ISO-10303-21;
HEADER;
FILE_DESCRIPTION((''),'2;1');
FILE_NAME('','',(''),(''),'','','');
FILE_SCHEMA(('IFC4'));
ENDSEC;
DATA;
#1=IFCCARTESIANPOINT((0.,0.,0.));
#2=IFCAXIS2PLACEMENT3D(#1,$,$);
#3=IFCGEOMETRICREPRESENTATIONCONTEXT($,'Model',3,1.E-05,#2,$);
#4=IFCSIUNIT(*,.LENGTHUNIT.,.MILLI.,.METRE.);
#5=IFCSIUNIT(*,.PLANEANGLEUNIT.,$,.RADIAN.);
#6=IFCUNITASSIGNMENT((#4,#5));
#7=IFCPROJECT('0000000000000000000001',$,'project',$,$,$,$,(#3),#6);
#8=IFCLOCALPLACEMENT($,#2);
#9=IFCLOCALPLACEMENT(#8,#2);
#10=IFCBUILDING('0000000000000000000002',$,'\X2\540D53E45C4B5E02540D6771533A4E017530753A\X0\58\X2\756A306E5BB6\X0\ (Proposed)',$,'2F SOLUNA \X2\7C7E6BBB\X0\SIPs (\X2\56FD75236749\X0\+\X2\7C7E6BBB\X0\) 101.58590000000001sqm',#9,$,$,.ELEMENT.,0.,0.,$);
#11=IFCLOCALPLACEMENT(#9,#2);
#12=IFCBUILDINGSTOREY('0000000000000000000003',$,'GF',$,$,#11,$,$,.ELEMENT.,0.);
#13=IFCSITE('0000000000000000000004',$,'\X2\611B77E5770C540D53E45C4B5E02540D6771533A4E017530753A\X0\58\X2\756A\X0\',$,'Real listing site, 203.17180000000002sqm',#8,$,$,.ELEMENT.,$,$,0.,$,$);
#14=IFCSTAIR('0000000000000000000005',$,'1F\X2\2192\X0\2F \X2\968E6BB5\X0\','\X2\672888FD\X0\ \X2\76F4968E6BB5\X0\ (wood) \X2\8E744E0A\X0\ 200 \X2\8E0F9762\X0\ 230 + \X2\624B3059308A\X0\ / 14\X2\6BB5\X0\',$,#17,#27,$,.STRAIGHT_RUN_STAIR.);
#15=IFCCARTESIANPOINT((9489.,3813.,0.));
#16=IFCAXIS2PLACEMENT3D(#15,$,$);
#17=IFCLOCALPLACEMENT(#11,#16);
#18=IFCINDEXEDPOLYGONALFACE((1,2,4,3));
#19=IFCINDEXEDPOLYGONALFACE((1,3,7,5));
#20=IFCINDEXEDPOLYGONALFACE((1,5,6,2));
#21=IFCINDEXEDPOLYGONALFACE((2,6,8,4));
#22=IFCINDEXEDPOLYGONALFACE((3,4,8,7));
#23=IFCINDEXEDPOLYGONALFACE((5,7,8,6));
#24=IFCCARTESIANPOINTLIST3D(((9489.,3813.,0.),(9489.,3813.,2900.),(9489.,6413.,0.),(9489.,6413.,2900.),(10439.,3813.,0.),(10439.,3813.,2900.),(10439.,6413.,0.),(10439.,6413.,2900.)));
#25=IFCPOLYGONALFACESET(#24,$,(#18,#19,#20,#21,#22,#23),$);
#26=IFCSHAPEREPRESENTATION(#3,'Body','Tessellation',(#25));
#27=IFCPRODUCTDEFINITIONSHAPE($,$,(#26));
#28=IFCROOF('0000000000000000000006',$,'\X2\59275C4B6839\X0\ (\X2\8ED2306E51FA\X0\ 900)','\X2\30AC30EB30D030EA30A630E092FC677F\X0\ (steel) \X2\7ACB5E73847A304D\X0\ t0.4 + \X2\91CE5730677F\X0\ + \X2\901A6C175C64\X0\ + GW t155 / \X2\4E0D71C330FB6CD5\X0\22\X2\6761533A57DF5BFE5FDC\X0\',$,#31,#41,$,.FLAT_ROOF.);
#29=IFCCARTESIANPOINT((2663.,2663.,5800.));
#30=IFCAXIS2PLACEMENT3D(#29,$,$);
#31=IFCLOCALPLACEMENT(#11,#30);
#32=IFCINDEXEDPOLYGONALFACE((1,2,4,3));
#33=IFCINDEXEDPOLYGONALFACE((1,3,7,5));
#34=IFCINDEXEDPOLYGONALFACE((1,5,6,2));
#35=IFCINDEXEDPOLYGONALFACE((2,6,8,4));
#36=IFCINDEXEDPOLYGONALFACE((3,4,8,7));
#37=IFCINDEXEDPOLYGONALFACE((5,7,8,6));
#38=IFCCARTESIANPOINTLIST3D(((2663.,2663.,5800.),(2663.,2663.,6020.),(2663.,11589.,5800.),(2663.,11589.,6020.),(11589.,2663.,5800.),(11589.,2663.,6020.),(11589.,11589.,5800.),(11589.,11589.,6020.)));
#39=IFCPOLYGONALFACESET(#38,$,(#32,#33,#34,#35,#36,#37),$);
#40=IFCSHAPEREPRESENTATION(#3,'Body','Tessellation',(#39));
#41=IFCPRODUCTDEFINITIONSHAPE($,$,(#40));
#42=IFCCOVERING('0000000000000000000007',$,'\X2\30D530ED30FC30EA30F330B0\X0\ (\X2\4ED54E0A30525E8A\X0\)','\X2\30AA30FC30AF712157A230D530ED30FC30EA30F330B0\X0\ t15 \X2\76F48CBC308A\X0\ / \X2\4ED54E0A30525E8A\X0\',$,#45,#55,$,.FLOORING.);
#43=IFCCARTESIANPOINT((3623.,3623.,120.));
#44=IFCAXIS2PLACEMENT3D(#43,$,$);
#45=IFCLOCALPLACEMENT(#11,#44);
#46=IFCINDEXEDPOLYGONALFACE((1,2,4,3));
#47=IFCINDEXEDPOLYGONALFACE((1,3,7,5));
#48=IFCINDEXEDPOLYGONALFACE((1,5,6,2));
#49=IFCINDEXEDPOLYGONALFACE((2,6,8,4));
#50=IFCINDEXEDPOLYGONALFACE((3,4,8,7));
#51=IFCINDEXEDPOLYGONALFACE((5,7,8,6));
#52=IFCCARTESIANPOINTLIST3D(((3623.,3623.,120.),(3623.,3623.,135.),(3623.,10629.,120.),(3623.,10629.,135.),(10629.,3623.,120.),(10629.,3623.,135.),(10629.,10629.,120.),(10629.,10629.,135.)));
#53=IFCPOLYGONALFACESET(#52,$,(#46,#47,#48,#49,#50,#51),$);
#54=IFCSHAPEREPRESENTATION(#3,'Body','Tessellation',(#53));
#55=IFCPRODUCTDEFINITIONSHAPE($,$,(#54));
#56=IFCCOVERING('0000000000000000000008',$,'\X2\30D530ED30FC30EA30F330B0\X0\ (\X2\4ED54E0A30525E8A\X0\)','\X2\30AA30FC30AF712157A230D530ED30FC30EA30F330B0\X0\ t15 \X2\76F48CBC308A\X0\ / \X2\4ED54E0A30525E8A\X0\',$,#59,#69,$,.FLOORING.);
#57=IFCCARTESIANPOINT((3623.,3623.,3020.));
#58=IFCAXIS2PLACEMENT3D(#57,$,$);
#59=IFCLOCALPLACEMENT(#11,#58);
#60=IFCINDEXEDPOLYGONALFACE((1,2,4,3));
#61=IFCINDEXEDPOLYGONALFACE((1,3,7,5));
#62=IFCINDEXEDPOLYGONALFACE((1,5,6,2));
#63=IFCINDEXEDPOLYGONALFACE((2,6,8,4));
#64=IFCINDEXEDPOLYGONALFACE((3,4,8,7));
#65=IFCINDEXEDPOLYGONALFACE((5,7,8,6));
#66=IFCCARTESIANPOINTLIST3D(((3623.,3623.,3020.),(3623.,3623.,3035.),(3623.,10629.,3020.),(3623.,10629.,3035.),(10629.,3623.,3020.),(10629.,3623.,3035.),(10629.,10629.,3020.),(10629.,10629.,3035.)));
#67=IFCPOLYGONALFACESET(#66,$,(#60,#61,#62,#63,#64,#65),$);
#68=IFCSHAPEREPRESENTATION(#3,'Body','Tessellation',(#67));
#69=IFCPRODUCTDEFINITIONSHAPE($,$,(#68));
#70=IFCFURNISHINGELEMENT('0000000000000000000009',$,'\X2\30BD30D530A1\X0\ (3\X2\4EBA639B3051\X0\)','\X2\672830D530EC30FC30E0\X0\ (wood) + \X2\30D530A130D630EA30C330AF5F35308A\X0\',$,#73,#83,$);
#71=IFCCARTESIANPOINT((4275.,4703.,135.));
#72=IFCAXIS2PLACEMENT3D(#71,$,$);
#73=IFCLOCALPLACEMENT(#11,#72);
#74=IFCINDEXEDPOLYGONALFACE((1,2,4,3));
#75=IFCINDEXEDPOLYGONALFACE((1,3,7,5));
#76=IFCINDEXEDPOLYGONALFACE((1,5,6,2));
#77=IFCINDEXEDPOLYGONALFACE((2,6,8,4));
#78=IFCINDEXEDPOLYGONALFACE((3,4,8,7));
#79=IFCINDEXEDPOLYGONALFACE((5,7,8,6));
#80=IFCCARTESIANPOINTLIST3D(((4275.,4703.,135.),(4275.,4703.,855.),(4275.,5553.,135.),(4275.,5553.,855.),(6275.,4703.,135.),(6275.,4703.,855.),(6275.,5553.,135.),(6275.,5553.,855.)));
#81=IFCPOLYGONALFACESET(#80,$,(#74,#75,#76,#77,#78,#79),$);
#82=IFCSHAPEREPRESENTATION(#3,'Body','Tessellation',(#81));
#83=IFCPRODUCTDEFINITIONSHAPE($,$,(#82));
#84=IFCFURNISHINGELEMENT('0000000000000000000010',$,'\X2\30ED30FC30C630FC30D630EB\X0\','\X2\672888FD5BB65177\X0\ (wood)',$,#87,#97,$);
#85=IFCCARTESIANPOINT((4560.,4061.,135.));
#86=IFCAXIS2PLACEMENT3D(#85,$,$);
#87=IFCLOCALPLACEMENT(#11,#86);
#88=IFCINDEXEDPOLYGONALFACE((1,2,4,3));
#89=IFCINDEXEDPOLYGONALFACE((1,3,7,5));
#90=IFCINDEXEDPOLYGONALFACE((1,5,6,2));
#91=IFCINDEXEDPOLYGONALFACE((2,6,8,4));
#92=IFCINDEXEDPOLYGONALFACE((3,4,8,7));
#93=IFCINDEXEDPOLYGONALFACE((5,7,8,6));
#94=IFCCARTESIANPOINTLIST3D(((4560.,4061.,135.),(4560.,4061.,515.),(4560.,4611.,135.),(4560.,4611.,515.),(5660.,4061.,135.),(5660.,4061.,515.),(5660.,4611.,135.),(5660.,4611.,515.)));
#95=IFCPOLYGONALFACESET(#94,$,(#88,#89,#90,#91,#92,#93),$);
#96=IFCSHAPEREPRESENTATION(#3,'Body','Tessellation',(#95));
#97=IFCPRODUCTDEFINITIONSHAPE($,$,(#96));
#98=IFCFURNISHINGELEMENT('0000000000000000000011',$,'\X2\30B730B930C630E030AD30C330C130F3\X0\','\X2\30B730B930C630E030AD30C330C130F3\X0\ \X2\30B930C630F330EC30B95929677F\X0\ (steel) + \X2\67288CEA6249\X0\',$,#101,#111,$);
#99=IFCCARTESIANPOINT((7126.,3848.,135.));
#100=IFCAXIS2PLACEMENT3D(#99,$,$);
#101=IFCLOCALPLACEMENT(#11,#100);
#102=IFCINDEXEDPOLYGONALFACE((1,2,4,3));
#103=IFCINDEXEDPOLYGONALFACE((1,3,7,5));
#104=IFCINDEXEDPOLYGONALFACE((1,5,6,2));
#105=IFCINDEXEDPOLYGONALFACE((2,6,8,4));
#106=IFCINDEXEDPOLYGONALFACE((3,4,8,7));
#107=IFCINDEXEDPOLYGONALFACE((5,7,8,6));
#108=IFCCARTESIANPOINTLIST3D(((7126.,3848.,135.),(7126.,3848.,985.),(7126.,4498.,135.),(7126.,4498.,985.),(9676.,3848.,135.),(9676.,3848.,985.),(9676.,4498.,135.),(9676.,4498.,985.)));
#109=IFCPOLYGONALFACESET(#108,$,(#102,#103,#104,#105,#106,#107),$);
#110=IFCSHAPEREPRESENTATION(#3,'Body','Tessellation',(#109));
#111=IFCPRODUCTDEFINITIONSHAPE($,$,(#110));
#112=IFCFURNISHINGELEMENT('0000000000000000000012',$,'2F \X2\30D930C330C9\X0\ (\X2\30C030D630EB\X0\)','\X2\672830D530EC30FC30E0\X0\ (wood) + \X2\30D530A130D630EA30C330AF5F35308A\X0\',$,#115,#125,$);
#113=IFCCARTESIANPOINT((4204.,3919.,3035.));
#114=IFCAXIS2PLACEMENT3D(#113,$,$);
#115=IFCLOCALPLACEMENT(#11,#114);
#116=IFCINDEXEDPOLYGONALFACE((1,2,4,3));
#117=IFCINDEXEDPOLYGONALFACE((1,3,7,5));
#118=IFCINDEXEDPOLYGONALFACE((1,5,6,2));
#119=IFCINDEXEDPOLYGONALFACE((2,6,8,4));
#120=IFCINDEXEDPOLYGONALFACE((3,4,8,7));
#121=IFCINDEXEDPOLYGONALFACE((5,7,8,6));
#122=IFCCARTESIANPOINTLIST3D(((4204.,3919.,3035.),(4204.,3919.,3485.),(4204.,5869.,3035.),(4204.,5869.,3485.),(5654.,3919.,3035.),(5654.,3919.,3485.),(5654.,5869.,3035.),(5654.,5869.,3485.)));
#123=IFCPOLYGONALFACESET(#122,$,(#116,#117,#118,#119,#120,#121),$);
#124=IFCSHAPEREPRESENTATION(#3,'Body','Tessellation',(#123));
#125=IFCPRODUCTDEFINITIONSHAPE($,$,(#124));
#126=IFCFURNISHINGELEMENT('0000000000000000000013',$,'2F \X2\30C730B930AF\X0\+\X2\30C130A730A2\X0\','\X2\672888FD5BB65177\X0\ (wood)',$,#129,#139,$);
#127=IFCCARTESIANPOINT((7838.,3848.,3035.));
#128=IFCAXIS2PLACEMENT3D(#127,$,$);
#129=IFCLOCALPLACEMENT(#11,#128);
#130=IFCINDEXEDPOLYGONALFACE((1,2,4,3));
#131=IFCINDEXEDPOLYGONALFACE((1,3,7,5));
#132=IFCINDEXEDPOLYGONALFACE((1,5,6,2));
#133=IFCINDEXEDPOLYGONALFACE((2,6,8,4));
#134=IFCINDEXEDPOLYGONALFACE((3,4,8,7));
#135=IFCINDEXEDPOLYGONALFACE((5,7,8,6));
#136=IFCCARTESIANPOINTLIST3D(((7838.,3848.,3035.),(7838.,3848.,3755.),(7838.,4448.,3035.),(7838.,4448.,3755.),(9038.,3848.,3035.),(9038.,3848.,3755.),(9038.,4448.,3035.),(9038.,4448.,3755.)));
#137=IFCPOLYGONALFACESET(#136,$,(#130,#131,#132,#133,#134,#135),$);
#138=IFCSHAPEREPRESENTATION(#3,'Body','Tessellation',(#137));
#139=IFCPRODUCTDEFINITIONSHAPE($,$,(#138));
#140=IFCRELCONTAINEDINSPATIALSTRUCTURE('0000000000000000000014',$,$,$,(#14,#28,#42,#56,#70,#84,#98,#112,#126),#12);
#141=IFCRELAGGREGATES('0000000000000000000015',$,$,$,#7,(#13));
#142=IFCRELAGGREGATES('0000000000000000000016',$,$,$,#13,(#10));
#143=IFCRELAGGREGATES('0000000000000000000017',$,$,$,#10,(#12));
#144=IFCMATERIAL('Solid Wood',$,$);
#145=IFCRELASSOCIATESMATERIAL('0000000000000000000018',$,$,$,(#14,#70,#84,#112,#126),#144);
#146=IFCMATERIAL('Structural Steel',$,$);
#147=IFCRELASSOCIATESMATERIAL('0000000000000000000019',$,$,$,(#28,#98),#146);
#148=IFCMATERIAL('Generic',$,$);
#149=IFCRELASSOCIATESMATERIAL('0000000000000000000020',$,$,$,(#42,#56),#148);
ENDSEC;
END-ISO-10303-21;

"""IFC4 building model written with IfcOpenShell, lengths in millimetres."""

from ifc_helpers import new_model, si_unit, frame, frame_2d, origin, place, context, project, spatial, rectangle, extrude, material, element, save


model = new_model("IFC4")

# Units and contexts
model_context = context("Model", 3, precision=1e-05, world=origin())
ifc_project = project(units=[si_unit("LENGTHUNIT", "METRE", prefix="MILLI"), si_unit("PLANEANGLEUNIT", "RADIAN")], contexts=[model_context])

# Site, building, storey
site_placement = place(None, origin())
site = spatial("IfcSite", under=ifc_project, at=site_placement, Name="愛知県名古屋市名東区丁田町58番", ObjectType="Real listing site, 203.17180000000002sqm", CompositionType="ELEMENT", RefElevation=0.0)
building_placement = place(site_placement, origin())
building = spatial("IfcBuilding", under=site, at=building_placement, Name="名古屋市名東区丁田町58番の家 (Proposed)", ObjectType="2F SOLUNA 籾殻SIPs (国産杉+籾殻) 101.58590000000001sqm", CompositionType="ELEMENT", ElevationOfRefHeight=0.0, ElevationOfTerrain=0.0)
storey_placement = place(building_placement, origin())
storey = spatial("IfcBuildingStorey", under=building, at=storey_placement, Name="GF", CompositionType="ELEMENT", Elevation=0.0)

# Shared definitions
ifc_material_1 = material(Name="Solid Wood")

# Stair
stair_placement = place(storey_placement, frame((9489.0, 3813.0, 0.0)))
element("IfcStair", 1, at=stair_placement, inside=storey, material=ifc_material_1, Name="1F→2F 階段", Description="木製 直階段 (wood) 蹴上 200 踏面 230 + 手すり / 14段", PredefinedType="STRAIGHT_RUN_STAIR", context=model_context, shape_type="SweptSolid", body=[
    extrude(rectangle(XDim=950.0, YDim=2600.0, at=frame_2d((475.0, 1300.0))), frame((9489.0, 3813.0, 0.0)), (0.0, 0.0, 1.0), 2900.0),
])

# Roof
ifc_material_2 = material(Name="Structural Steel")
roof_placement = place(storey_placement, frame((2663.0, 2663.0, 5800.0)))
element("IfcRoof", 2, at=roof_placement, inside=storey, material=ifc_material_2, Name="大屋根 (軒の出 900)", Description="ガルバリウム鋼板 (steel) 立平葺き t0.4 + 野地板 + 通気層 + GW t155 / 不燃・法22条区域対応", PredefinedType="FLAT_ROOF", context=model_context, shape_type="SweptSolid", body=[
    extrude(rectangle(XDim=8926.0, YDim=8926.0, at=frame_2d((4463.0, 4463.0))), frame((2663.0, 2663.0, 5800.0)), (0.0, 0.0, 1.0), 220.0),
])

# Coverings
ifc_material_3 = material(Name="Generic")
covering_1_placement = place(storey_placement, frame((3623.0, 3623.0, 120.0)))
element("IfcCovering", 3, at=covering_1_placement, inside=storey, material=ifc_material_3, Name="フローリング (仕上げ床)", Description="オーク無垢フローリング t15 直貼り / 仕上げ床", PredefinedType="FLOORING", context=model_context, shape_type="SweptSolid", body=[
    extrude(rectangle(XDim=7006.0, YDim=7006.0, at=frame_2d((3503.0, 3503.0))), frame((3623.0, 3623.0, 120.0)), (0.0, 0.0, 1.0), 15.0),
])
covering_2_placement = place(storey_placement, frame((3623.0, 3623.0, 3020.0)))
element("IfcCovering", 4, at=covering_2_placement, inside=storey, material=ifc_material_3, Name="フローリング (仕上げ床)", Description="オーク無垢フローリング t15 直貼り / 仕上げ床", PredefinedType="FLOORING", context=model_context, shape_type="SweptSolid", body=[
    extrude(rectangle(XDim=7006.0, YDim=7006.0, at=frame_2d((3503.0, 3503.0))), frame((3623.0, 3623.0, 3020.0)), (0.0, 0.0, 1.0), 15.0),
])

# Furnishing elements
furnishing_1_placement = place(storey_placement, frame((4275.0, 4703.0, 135.0)))
element("IfcFurnishingElement", 5, at=furnishing_1_placement, inside=storey, material=ifc_material_1, Name="ソファ (3人掛け)", Description="木フレーム (wood) + ファブリック張り", context=model_context, shape_type="SweptSolid", body=[
    extrude(rectangle(XDim=2000.0, YDim=850.0, at=frame_2d((1000.0, 425.0))), frame((4275.0, 4703.0, 135.0)), (0.0, 0.0, 1.0), 720.0),
])
furnishing_2_placement = place(storey_placement, frame((4560.0, 4061.0, 135.0)))
element("IfcFurnishingElement", 6, at=furnishing_2_placement, inside=storey, material=ifc_material_1, Name="ローテーブル", Description="木製家具 (wood)", context=model_context, shape_type="SweptSolid", body=[
    extrude(rectangle(XDim=1100.0, YDim=550.0, at=frame_2d((550.0, 275.0))), frame((4560.0, 4061.0, 135.0)), (0.0, 0.0, 1.0), 380.0),
])
furnishing_3_placement = place(storey_placement, frame((7126.0, 3848.0, 135.0)))
element("IfcFurnishingElement", 7, at=furnishing_3_placement, inside=storey, material=ifc_material_2, Name="システムキッチン", Description="システムキッチン ステンレス天板 (steel) + 木質扉", context=model_context, shape_type="SweptSolid", body=[
    extrude(rectangle(XDim=2550.0, YDim=650.0, at=frame_2d((1275.0, 325.0))), frame((7126.0, 3848.0, 135.0)), (0.0, 0.0, 1.0), 850.0),
])
furnishing_4_placement = place(storey_placement, frame((4204.0, 3919.0, 3035.0)))
element("IfcFurnishingElement", 8, at=furnishing_4_placement, inside=storey, material=ifc_material_1, Name="2F ベッド (ダブル)", Description="木フレーム (wood) + ファブリック張り", context=model_context, shape_type="SweptSolid", body=[
    extrude(rectangle(XDim=1450.0, YDim=1950.0, at=frame_2d((725.0, 975.0))), frame((4204.0, 3919.0, 3035.0)), (0.0, 0.0, 1.0), 450.0),
])
furnishing_5_placement = place(storey_placement, frame((7838.0, 3848.0, 3035.0)))
element("IfcFurnishingElement", 9, at=furnishing_5_placement, inside=storey, material=ifc_material_1, Name="2F デスク+チェア", Description="木製家具 (wood)", context=model_context, shape_type="SweptSolid", body=[
    extrude(rectangle(XDim=1200.0, YDim=600.0, at=frame_2d((600.0, 300.0))), frame((7838.0, 3848.0, 3035.0)), (0.0, 0.0, 1.0), 720.0),
])

save(model, "model.ifc")
